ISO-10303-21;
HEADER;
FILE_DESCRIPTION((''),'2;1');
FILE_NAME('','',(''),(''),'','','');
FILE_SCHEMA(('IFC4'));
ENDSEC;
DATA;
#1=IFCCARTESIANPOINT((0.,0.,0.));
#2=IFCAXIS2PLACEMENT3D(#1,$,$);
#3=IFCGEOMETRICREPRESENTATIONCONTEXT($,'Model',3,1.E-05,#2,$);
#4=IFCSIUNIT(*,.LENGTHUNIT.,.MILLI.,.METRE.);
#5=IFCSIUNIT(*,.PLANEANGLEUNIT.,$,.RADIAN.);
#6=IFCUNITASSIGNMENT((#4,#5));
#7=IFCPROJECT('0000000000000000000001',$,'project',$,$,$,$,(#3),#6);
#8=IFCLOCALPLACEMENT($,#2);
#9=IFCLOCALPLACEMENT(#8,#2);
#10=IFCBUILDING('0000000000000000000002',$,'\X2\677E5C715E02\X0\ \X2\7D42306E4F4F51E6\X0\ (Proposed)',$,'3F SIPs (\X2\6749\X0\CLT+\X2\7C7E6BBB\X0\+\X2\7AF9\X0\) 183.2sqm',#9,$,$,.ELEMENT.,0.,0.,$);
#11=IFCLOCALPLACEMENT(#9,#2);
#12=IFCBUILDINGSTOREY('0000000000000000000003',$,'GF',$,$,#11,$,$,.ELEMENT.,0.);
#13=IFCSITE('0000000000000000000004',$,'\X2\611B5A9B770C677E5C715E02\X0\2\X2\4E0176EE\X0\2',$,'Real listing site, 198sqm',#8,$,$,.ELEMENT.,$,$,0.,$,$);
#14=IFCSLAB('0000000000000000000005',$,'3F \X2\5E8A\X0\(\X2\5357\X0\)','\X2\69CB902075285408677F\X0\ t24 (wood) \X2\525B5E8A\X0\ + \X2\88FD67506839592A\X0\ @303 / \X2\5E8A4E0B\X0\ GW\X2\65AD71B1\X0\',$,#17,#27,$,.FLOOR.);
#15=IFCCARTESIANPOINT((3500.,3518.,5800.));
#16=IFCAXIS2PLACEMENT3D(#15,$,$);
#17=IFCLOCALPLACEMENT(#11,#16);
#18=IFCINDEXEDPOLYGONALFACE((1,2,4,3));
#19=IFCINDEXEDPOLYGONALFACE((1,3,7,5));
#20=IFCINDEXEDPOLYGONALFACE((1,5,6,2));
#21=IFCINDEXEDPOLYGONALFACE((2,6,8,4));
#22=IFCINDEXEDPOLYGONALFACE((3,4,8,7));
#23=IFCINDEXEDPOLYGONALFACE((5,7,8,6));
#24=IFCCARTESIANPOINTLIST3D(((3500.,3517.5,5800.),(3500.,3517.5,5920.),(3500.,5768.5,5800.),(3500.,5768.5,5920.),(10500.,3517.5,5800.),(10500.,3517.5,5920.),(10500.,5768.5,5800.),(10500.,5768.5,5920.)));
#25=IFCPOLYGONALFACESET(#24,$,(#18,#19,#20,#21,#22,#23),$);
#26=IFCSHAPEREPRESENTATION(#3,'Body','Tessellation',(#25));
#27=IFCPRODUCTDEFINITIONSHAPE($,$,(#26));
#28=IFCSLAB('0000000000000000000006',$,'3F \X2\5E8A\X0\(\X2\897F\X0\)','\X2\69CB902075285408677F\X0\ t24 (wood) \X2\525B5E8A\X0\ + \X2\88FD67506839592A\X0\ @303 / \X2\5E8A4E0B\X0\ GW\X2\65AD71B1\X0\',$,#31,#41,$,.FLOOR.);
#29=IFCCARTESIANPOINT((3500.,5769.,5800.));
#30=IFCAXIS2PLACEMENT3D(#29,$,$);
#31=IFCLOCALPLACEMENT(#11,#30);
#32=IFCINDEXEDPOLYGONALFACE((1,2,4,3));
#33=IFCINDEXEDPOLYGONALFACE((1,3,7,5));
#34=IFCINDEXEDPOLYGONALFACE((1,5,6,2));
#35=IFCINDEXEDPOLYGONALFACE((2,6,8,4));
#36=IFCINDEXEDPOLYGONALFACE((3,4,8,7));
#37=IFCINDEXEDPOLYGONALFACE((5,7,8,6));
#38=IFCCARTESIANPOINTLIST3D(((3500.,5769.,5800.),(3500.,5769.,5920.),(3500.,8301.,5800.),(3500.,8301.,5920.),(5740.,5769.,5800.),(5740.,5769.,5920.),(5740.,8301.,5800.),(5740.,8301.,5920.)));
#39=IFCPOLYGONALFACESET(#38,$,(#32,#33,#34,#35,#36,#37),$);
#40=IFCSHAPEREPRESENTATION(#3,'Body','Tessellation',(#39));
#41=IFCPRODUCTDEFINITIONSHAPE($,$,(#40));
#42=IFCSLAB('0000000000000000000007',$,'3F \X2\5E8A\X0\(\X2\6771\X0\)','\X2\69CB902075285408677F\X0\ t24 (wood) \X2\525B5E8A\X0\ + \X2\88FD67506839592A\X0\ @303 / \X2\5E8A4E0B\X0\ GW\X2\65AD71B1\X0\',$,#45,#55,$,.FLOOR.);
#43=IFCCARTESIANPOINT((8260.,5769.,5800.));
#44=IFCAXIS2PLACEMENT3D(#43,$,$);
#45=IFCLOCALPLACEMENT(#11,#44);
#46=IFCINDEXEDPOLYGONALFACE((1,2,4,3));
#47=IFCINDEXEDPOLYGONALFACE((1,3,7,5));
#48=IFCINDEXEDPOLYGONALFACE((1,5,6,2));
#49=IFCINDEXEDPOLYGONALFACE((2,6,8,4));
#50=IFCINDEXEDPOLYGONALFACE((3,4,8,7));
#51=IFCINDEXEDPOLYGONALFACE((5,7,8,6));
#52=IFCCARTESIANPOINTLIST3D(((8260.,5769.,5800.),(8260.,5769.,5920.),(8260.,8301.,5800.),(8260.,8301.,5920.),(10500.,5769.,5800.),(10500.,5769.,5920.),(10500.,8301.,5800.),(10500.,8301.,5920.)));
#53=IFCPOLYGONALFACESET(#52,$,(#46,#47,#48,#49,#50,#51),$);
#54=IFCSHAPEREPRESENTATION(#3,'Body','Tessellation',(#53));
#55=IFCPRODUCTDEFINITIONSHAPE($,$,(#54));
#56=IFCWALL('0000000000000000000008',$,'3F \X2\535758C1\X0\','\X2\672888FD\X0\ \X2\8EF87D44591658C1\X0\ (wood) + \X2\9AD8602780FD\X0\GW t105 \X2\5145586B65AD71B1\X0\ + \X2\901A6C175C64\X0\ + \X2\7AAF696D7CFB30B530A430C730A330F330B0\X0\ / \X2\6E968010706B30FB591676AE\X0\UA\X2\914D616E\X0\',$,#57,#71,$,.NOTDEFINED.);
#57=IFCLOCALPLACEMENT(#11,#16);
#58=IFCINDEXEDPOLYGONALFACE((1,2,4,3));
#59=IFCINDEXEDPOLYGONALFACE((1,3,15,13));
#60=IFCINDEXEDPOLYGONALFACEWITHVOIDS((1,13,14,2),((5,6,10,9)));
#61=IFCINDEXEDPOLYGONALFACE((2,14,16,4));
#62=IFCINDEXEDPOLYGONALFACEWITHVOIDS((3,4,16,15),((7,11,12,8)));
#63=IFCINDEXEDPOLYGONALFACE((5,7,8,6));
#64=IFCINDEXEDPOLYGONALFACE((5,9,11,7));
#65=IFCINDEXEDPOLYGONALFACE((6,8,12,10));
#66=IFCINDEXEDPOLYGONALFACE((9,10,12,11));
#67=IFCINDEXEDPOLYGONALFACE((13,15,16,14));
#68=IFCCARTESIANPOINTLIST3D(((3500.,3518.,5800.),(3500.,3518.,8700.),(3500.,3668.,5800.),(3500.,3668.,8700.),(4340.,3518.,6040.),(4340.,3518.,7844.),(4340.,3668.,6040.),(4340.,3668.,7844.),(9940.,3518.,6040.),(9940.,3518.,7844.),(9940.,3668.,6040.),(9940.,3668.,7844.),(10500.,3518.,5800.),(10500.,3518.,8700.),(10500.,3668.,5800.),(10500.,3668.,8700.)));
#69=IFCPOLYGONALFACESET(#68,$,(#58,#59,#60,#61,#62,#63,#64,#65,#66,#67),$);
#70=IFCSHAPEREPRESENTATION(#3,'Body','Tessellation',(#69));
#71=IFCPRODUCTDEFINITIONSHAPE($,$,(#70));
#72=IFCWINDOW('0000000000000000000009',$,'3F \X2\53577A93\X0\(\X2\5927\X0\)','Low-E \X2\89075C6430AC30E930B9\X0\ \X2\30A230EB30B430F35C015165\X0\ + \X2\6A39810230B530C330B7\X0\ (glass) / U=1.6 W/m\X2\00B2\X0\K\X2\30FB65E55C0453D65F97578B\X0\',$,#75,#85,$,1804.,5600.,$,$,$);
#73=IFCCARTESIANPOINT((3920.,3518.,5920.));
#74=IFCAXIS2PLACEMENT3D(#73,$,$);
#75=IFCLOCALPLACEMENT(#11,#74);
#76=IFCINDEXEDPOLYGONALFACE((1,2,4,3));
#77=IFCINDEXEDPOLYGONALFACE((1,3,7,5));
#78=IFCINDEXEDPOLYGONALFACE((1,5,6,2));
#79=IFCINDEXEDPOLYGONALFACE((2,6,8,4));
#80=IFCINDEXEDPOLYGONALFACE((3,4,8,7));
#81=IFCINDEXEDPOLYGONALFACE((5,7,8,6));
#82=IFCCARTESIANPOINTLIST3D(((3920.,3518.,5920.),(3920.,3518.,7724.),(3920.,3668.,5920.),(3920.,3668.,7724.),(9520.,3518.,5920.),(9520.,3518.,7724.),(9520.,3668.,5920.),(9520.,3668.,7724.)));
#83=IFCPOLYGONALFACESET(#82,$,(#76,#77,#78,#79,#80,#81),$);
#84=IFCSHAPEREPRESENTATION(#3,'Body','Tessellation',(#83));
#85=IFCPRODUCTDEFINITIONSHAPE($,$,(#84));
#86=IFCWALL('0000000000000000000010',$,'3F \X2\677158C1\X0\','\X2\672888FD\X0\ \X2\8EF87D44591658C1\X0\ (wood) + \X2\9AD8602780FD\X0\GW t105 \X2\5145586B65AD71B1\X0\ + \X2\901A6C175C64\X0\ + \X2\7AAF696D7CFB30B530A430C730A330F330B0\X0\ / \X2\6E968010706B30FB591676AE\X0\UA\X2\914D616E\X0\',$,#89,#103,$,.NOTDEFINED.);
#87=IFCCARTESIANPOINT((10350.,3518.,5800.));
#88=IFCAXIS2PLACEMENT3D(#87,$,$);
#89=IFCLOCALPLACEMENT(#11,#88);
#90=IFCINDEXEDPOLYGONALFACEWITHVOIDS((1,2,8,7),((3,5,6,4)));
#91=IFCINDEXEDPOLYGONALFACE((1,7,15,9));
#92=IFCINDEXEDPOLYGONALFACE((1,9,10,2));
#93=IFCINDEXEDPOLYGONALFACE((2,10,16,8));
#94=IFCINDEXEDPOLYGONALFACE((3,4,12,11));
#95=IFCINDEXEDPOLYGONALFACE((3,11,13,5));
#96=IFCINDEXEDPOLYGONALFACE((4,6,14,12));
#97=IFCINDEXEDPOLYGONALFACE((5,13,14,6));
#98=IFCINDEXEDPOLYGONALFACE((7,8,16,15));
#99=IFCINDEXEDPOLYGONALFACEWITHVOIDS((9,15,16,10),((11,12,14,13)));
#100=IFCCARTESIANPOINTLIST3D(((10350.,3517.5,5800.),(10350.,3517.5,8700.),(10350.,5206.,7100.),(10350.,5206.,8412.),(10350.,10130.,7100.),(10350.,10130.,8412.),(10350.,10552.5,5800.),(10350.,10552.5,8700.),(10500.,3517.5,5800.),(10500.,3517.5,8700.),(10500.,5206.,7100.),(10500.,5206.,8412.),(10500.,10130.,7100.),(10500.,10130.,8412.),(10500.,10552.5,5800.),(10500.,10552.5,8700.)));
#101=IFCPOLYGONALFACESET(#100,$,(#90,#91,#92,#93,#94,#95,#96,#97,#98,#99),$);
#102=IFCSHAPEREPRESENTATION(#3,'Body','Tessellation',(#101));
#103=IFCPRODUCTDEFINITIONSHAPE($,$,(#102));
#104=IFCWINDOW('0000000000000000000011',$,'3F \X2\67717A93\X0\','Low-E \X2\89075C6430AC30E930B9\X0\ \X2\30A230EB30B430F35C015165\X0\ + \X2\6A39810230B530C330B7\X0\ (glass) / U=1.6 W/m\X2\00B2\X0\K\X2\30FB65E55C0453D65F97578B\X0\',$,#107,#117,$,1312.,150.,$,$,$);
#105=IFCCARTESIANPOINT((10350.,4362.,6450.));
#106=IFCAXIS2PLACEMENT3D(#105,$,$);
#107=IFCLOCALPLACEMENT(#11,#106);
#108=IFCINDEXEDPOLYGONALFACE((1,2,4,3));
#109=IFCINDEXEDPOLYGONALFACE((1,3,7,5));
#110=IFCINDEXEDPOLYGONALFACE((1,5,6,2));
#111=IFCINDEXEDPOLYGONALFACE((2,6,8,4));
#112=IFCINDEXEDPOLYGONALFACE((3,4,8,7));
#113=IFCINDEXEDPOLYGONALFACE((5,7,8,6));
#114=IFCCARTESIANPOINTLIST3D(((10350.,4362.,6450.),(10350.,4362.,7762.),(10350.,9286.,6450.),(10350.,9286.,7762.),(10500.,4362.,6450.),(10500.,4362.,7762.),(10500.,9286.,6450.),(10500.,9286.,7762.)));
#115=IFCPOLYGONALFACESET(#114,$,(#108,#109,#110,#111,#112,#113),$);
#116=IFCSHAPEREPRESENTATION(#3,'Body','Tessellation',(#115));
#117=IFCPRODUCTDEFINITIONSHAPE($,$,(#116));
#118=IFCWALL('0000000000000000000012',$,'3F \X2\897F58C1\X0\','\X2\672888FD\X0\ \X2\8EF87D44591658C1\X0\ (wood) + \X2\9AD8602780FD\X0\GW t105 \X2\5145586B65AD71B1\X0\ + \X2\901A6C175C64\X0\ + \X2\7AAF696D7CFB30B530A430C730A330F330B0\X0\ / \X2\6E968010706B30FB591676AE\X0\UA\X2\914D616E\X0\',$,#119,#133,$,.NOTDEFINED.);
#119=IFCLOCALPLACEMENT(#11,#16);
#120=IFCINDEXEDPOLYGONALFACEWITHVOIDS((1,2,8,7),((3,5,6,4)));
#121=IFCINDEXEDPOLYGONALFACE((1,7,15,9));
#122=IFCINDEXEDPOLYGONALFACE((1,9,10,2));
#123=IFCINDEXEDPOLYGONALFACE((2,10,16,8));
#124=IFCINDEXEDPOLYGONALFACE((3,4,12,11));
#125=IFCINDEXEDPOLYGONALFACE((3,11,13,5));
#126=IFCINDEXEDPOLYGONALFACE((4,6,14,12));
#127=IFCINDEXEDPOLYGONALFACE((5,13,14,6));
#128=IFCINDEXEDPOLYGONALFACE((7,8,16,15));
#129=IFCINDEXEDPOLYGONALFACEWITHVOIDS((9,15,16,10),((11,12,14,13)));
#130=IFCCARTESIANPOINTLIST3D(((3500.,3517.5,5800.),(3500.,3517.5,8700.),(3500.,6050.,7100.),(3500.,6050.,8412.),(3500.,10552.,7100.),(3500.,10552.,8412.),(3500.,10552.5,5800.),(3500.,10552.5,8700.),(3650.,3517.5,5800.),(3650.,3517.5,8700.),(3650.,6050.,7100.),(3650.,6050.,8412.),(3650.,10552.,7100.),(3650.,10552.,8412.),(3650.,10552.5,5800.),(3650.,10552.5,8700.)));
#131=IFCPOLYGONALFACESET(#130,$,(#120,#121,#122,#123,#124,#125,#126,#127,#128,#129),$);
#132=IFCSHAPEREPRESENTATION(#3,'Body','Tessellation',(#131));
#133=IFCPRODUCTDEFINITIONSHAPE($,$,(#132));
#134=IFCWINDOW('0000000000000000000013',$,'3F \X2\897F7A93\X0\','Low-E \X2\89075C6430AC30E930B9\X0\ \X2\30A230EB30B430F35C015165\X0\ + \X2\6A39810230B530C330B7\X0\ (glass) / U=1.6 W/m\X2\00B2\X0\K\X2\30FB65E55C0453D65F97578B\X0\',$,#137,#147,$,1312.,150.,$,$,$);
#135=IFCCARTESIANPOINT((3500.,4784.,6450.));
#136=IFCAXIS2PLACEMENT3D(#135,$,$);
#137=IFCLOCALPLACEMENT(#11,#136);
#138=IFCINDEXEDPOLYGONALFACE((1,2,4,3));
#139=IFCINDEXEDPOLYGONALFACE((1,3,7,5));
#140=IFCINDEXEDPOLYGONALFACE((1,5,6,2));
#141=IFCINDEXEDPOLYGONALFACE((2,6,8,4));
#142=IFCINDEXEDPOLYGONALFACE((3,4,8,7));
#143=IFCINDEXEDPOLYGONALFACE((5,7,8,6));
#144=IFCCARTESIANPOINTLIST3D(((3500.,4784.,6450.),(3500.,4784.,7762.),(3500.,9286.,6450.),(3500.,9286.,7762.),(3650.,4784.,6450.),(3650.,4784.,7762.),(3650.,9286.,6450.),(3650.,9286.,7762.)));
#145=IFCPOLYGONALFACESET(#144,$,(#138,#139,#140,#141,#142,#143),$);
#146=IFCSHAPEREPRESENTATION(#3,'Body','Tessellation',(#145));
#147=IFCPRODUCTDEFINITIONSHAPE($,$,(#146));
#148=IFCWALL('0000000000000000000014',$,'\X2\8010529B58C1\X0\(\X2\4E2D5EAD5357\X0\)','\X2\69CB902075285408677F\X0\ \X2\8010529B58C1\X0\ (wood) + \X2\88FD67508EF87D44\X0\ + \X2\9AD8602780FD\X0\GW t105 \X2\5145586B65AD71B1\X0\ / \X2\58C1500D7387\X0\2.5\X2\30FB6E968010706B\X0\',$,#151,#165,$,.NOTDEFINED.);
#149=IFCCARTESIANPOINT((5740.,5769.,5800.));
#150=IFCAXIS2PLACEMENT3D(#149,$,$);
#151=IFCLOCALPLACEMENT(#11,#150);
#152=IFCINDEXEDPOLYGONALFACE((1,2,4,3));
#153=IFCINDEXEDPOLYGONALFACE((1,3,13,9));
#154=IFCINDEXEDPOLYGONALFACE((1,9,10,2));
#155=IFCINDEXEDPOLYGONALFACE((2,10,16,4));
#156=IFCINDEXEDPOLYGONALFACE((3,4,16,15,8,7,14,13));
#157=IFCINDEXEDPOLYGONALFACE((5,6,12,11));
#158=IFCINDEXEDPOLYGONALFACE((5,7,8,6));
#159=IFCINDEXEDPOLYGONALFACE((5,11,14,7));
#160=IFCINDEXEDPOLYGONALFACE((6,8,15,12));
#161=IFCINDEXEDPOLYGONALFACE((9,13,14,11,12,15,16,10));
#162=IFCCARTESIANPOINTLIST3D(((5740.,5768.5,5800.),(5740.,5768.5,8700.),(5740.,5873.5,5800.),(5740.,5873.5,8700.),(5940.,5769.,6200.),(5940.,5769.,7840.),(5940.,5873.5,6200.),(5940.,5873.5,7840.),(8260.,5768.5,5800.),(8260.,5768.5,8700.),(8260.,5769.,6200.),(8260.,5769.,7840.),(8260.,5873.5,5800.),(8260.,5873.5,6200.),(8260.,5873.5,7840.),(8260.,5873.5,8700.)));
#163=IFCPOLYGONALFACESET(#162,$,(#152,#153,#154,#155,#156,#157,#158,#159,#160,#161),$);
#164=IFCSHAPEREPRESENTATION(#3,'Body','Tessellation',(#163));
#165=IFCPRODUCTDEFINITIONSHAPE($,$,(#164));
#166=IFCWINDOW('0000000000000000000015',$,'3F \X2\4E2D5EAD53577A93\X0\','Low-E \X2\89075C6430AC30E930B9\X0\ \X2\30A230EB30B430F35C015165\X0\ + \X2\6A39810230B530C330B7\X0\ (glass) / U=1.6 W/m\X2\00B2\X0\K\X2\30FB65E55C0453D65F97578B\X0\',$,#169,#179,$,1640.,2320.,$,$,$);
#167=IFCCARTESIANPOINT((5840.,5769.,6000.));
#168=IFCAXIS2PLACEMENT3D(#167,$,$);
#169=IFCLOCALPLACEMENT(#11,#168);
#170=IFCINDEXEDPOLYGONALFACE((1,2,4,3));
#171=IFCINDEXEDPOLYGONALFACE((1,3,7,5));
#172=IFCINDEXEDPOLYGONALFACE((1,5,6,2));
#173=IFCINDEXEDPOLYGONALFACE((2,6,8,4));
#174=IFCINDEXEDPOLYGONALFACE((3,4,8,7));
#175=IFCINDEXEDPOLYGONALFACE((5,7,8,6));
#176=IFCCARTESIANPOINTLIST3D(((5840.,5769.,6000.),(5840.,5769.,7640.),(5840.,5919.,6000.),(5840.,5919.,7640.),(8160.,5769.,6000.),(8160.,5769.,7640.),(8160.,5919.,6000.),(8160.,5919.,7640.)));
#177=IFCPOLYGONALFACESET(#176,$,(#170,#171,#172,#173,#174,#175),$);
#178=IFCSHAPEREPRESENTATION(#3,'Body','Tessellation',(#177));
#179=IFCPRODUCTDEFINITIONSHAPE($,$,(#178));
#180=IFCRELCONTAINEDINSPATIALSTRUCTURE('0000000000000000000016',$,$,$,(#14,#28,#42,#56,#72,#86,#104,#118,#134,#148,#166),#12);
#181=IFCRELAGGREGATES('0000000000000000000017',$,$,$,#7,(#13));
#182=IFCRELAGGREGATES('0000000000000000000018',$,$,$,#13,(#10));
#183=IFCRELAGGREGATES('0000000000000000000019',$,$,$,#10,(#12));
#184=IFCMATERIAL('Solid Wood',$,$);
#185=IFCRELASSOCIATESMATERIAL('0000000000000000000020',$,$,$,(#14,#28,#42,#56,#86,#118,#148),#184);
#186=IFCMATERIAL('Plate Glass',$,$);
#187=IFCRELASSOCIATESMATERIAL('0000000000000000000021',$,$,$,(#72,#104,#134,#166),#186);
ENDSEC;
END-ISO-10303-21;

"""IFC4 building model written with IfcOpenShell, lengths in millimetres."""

from ifc_helpers import new_model, si_unit, frame, frame_2d, origin, place, context, project, spatial, rectangle, extrude, material, element, fill, save


model = new_model("IFC4")

# Units and contexts
model_context = context("Model", 3, precision=1e-05, world=origin())
ifc_project = project(units=[si_unit("LENGTHUNIT", "METRE", prefix="MILLI"), si_unit("PLANEANGLEUNIT", "RADIAN")], contexts=[model_context])

# Site, building, storey
site_placement = place(None, origin())
site = spatial("IfcSite", under=ifc_project, at=site_placement, Name="愛媛県松山市2丁目2", ObjectType="Real listing site, 198sqm", CompositionType="ELEMENT", RefElevation=0.0)
building_placement = place(site_placement, origin())
building = spatial("IfcBuilding", under=site, at=building_placement, Name="松山市 終の住処 (Proposed)", ObjectType="3F SIPs (杉CLT+籾殻+竹) 183.2sqm", CompositionType="ELEMENT", ElevationOfRefHeight=0.0, ElevationOfTerrain=0.0)
storey_placement = place(building_placement, origin())
storey = spatial("IfcBuildingStorey", under=building, at=storey_placement, Name="GF", CompositionType="ELEMENT", Elevation=0.0)

# Slabs
ifc_material_1 = material(Name="Solid Wood")
slab_1_placement = place(storey_placement, frame((3500.0, 3518.0, 5800.0)))
element("IfcSlab", 1, at=slab_1_placement, inside=storey, material=ifc_material_1, Name="3F 床(南)", Description="構造用合板 t24 (wood) 剛床 + 製材根太 @303 / 床下 GW断熱", PredefinedType="FLOOR", context=model_context, shape_type="SweptSolid", body=[
    extrude(rectangle(XDim=7000.0, YDim=2251.0, at=frame_2d((3500.0, 1125.0))), frame((3500.0, 3518.0, 5800.0)), (0.0, 0.0, 1.0), 120.0),
])
slab_2_placement = place(storey_placement, frame((3500.0, 5769.0, 5800.0)))
element("IfcSlab", 2, at=slab_2_placement, inside=storey, material=ifc_material_1, Name="3F 床(西)", Description="構造用合板 t24 (wood) 剛床 + 製材根太 @303 / 床下 GW断熱", PredefinedType="FLOOR", context=model_context, shape_type="SweptSolid", body=[
    extrude(rectangle(XDim=2240.0, YDim=2532.0, at=frame_2d((1120.0, 1266.0))), frame((3500.0, 5769.0, 5800.0)), (0.0, 0.0, 1.0), 120.0),
])
slab_3_placement = place(storey_placement, frame((8260.0, 5769.0, 5800.0)))
element("IfcSlab", 3, at=slab_3_placement, inside=storey, material=ifc_material_1, Name="3F 床(東)", Description="構造用合板 t24 (wood) 剛床 + 製材根太 @303 / 床下 GW断熱", PredefinedType="FLOOR", context=model_context, shape_type="SweptSolid", body=[
    extrude(rectangle(XDim=2240.0, YDim=2532.0, at=frame_2d((1120.0, 1266.0))), frame((8260.0, 5769.0, 5800.0)), (0.0, 0.0, 1.0), 120.0),
])

# Walls, openings, windows
wall_1_placement = place(storey_placement, frame((3500.0, 3518.0, 5800.0)))
wall_1 = element("IfcWall", 4, at=wall_1_placement, inside=storey, material=ifc_material_1, Name="3F 南壁", Description="木製 軸組外壁 (wood) + 高性能GW t105 充填断熱 + 通気層 + 窯業系サイディング / 準耐火・外皮UA配慮", PredefinedType="NOTDEFINED", context=model_context, shape_type="SweptSolid", body=[
    extrude(rectangle(XDim=7000.0, YDim=150.0, at=frame_2d((3500.0, 75.0))), frame((3500.0, 3518.0, 5800.0)), (0.0, 0.0, 1.0), 2900.0),
])
opening_1_placement = place(storey_placement, frame((3920.0, 3518.0, 5920.0)))
opening_1 = element("IfcOpeningElement", 5, at=opening_1_placement, cuts=wall_1, PredefinedType="NOTDEFINED", context=model_context, shape_type="SweptSolid", body=[
    extrude(rectangle(XDim=5600.0, YDim=150.0, at=frame_2d((2800.0, 75.0))), frame((3920.0, 3518.0, 5920.0)), (0.0, 0.0, 1.0), 1804.0),
])
ifc_material_2 = material(Name="Plate Glass")
window_1_placement = place(storey_placement, frame((3920.0, 3518.0, 5920.0)))
window_1 = element("IfcWindow", 6, at=window_1_placement, inside=storey, material=ifc_material_2, Name="3F 南窓(大)", Description="Low-E 複層ガラス アルゴン封入 + 樹脂サッシ (glass) / U=1.6 W/m²K・日射取得型", OverallHeight=1804.0, OverallWidth=5600.0, context=model_context, shape_type="SweptSolid", body=[
    extrude(rectangle(XDim=5600.0, YDim=150.0, at=frame_2d((2800.0, 75.0))), frame((3920.0, 3518.0, 5920.0)), (0.0, 0.0, 1.0), 1804.0),
])
fill(opening_1, window_1)
wall_2_placement = place(storey_placement, frame((10350.0, 3518.0, 5800.0)))
wall_2 = element("IfcWall", 7, at=wall_2_placement, inside=storey, material=ifc_material_1, Name="3F 東壁", Description="木製 軸組外壁 (wood) + 高性能GW t105 充填断熱 + 通気層 + 窯業系サイディング / 準耐火・外皮UA配慮", PredefinedType="NOTDEFINED", context=model_context, shape_type="SweptSolid", body=[
    extrude(rectangle(XDim=150.0, YDim=7035.0, at=frame_2d((75.0, 3517.0))), frame((10350.0, 3518.0, 5800.0)), (0.0, 0.0, 1.0), 2900.0),
])
opening_2_placement = place(storey_placement, frame((10350.0, 4362.0, 6450.0)))
opening_2 = element("IfcOpeningElement", 8, at=opening_2_placement, cuts=wall_2, PredefinedType="NOTDEFINED", context=model_context, shape_type="SweptSolid", body=[
    extrude(rectangle(XDim=150.0, YDim=4924.0, at=frame_2d((75.0, 2462.0))), frame((10350.0, 4362.0, 6450.0)), (0.0, 0.0, 1.0), 1312.0),
])
window_2_placement = place(storey_placement, frame((10350.0, 4362.0, 6450.0)))
window_2 = element("IfcWindow", 9, at=window_2_placement, inside=storey, material=ifc_material_2, Name="3F 東窓", Description="Low-E 複層ガラス アルゴン封入 + 樹脂サッシ (glass) / U=1.6 W/m²K・日射取得型", OverallHeight=1312.0, OverallWidth=150.0, context=model_context, shape_type="SweptSolid", body=[
    extrude(rectangle(XDim=150.0, YDim=4924.0, at=frame_2d((75.0, 2462.0))), frame((10350.0, 4362.0, 6450.0)), (0.0, 0.0, 1.0), 1312.0),
])
fill(opening_2, window_2)
wall_3_placement = place(storey_placement, frame((3500.0, 3518.0, 5800.0)))
wall_3 = element("IfcWall", 10, at=wall_3_placement, inside=storey, material=ifc_material_1, Name="3F 西壁", Description="木製 軸組外壁 (wood) + 高性能GW t105 充填断熱 + 通気層 + 窯業系サイディング / 準耐火・外皮UA配慮", PredefinedType="NOTDEFINED", context=model_context, shape_type="SweptSolid", body=[
    extrude(rectangle(XDim=150.0, YDim=7035.0, at=frame_2d((75.0, 3517.0))), frame((3500.0, 3518.0, 5800.0)), (0.0, 0.0, 1.0), 2900.0),
])
opening_3_placement = place(storey_placement, frame((3500.0, 4784.0, 6450.0)))
opening_3 = element("IfcOpeningElement", 11, at=opening_3_placement, cuts=wall_3, PredefinedType="NOTDEFINED", context=model_context, shape_type="SweptSolid", body=[
    extrude(rectangle(XDim=150.0, YDim=4502.0, at=frame_2d((75.0, 2251.0))), frame((3500.0, 4784.0, 6450.0)), (0.0, 0.0, 1.0), 1312.0),
])
window_3_placement = place(storey_placement, frame((3500.0, 4784.0, 6450.0)))
window_3 = element("IfcWindow", 12, at=window_3_placement, inside=storey, material=ifc_material_2, Name="3F 西窓", Description="Low-E 複層ガラス アルゴン封入 + 樹脂サッシ (glass) / U=1.6 W/m²K・日射取得型", OverallHeight=1312.0, OverallWidth=150.0, context=model_context, shape_type="SweptSolid", body=[
    extrude(rectangle(XDim=150.0, YDim=4502.0, at=frame_2d((75.0, 2251.0))), frame((3500.0, 4784.0, 6450.0)), (0.0, 0.0, 1.0), 1312.0),
])
fill(opening_3, window_3)
wall_4_placement = place(storey_placement, frame((5740.0, 5769.0, 5800.0)))
wall_4 = element("IfcWall", 13, at=wall_4_placement, inside=storey, material=ifc_material_1, Name="耐力壁(中庭南)", Description="構造用合板 耐力壁 (wood) + 製材軸組 + 高性能GW t105 充填断熱 / 壁倍率2.5・準耐火", PredefinedType="NOTDEFINED", context=model_context, shape_type="SweptSolid", body=[
    extrude(rectangle(XDim=2520.0, YDim=105.0, at=frame_2d((1260.0, 52.0))), frame((5740.0, 5769.0, 5800.0)), (0.0, 0.0, 1.0), 2900.0),
])
opening_4_placement = place(storey_placement, frame((5840.0, 5769.0, 6000.0)))
opening_4 = element("IfcOpeningElement", 14, at=opening_4_placement, cuts=wall_4, PredefinedType="NOTDEFINED", context=model_context, shape_type="SweptSolid", body=[
    extrude(rectangle(XDim=2320.0, YDim=150.0, at=frame_2d((1160.0, 75.0))), frame((5840.0, 5769.0, 6000.0)), (0.0, 0.0, 1.0), 1640.0),
])
window_4_placement = place(storey_placement, frame((5840.0, 5769.0, 6000.0)))
window_4 = element("IfcWindow", 15, at=window_4_placement, inside=storey, material=ifc_material_2, Name="3F 中庭南窓", Description="Low-E 複層ガラス アルゴン封入 + 樹脂サッシ (glass) / U=1.6 W/m²K・日射取得型", OverallHeight=1640.0, OverallWidth=2320.0, context=model_context, shape_type="SweptSolid", body=[
    extrude(rectangle(XDim=2320.0, YDim=150.0, at=frame_2d((1160.0, 75.0))), frame((5840.0, 5769.0, 6000.0)), (0.0, 0.0, 1.0), 1640.0),
])
fill(opening_4, window_4)

save(model, "model.ifc")
